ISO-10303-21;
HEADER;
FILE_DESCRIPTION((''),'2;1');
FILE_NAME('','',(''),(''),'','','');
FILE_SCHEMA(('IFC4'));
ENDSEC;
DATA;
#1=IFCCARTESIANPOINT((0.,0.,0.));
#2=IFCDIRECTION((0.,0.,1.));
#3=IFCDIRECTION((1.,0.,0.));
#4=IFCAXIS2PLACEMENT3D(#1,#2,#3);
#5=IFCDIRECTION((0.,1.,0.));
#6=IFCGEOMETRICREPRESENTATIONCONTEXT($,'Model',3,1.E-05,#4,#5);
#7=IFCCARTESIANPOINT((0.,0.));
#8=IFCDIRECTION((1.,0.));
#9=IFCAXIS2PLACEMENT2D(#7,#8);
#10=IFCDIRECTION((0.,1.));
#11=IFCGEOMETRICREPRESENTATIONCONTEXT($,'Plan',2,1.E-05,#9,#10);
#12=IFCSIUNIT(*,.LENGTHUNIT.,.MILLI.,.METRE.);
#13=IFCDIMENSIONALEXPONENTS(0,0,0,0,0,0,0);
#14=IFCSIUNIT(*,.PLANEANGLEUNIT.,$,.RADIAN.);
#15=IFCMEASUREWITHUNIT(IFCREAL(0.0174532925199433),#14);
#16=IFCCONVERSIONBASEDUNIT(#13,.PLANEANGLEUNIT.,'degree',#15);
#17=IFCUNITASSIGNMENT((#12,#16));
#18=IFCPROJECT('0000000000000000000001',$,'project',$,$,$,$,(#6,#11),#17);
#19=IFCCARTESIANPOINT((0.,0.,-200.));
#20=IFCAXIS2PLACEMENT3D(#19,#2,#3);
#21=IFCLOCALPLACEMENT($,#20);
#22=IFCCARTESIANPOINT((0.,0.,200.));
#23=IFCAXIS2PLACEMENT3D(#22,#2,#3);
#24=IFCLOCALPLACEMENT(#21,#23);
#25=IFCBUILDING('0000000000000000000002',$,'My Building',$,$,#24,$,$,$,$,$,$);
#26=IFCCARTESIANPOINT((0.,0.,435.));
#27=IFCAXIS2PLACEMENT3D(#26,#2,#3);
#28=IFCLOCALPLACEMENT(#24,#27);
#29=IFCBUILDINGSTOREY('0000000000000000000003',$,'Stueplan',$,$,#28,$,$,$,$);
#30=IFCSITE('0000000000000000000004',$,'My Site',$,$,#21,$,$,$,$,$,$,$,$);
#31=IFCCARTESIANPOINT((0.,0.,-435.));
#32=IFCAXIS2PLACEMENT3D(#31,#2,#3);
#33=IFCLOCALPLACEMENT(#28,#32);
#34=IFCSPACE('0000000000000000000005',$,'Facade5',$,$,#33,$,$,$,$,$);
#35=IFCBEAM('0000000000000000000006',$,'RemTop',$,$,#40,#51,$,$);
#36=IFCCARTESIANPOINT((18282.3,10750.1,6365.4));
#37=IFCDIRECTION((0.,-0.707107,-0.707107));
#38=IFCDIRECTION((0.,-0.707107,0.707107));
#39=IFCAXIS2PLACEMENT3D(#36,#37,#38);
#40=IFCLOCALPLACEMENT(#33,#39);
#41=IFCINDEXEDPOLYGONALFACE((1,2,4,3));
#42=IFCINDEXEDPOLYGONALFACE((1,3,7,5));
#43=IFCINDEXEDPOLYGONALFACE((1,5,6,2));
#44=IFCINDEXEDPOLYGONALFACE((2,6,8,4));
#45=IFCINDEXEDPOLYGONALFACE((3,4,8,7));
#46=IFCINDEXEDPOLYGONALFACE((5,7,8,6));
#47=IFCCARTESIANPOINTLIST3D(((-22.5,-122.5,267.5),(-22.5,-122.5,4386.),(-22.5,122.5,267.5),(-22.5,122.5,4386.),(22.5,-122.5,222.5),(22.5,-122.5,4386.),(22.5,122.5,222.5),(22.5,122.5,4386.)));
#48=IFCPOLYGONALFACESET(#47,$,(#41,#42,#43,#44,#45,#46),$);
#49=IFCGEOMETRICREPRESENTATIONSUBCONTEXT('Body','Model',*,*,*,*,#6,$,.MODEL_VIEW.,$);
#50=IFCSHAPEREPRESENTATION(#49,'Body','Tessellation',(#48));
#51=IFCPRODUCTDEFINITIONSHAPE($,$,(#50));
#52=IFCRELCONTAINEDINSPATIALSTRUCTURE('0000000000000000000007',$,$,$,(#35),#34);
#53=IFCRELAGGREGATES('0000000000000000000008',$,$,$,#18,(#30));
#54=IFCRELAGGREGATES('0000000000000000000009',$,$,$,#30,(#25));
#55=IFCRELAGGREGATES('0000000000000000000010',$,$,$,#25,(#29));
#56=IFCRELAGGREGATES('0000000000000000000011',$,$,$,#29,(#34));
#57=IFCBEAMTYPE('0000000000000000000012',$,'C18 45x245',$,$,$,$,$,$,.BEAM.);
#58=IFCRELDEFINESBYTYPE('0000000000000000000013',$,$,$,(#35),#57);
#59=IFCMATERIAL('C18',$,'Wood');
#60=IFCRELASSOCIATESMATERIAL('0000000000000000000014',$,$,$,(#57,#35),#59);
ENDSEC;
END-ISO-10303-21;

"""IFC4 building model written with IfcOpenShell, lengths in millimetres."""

from ifc_helpers import new_model, entity, si_unit, converted_unit, direction, frame, origin_with_axes, origin_2d_with_axis, place, context, subcontext, project, spatial, rectangle, extrude, clip, halfspace, material, material_profile, profile_set, profile_usage, type_object, element, save


model = new_model("IFC4")

# Units and contexts
model_context = context("Model", 3, precision=1e-05, world=origin_with_axes(), true_north=direction((0.0, 1.0, 0.0)))
plan_context = context("Plan", 2, precision=1e-05, world=origin_2d_with_axis(), true_north=direction((0.0, 1.0)))
body_context_1 = subcontext(model_context, "Body", "Model", "MODEL_VIEW")
ifc_project = project(units=[si_unit("LENGTHUNIT", "METRE", prefix="MILLI"), converted_unit("PLANEANGLEUNIT", "degree", entity("IfcReal", 0.0174532925199433), si_unit("PLANEANGLEUNIT", "RADIAN"), dimensions=[0, 0, 0, 0, 0, 0, 0])], contexts=[model_context, plan_context])

# Site, building, storey
site_placement = place(None, frame((0.0, 0.0, -200.0), z_axis=(0.0, 0.0, 1.0), x_axis=(1.0, 0.0, 0.0)))
site = spatial("IfcSite", under=ifc_project, at=site_placement, Name="My Site")
building_placement = place(site_placement, frame((0.0, 0.0, 200.0), z_axis=(0.0, 0.0, 1.0), x_axis=(1.0, 0.0, 0.0)))
building = spatial("IfcBuilding", under=site, at=building_placement, Name="My Building")
storey_placement = place(building_placement, frame((0.0, 0.0, 435.0), z_axis=(0.0, 0.0, 1.0), x_axis=(1.0, 0.0, 0.0)))
storey = spatial("IfcBuildingStorey", under=building, at=storey_placement, Name="Stueplan")

# Shared definitions
ifc_material = material(Name="C18", Category="Wood")

# Shared definitions
space_1_placement = place(storey_placement, frame((0.0, 0.0, -435.0), z_axis=(0.0, 0.0, 1.0), x_axis=(1.0, 0.0, 0.0)))
space_1 = spatial("IfcSpace", under=storey, at=space_1_placement, Name="Facade5")

# Beam
ifc_material_profile_1 = material_profile(ifc_material, rectangle(XDim=45.0, YDim=245.0), Name="concrete")
ifc_profile_set_1 = profile_set([ifc_material_profile_1], Name="woodStructural")
beam_type_1 = type_object("IfcBeamType", Name="C18 45x245", PredefinedType="BEAM", material=ifc_profile_set_1)
ifc_profile_usage_1 = profile_usage(ifc_profile_set_1)
beam_1_placement = place(space_1_placement, frame((18282.3, 10750.1, 6365.4), z_axis=(0.0, -0.707107, -0.707107), x_axis=(0.0, -0.707107, 0.707107)))
element("IfcBeam", 1, at=beam_1_placement, inside=space_1, type_object=beam_type_1, material=ifc_profile_usage_1, Name="RemTop", context=body_context_1, shape_type="Clipping", body=[
    clip(extrude(rectangle(XDim=45.0, YDim=245.0), origin_with_axes(), (0.0, 0.0, 1.0), 4386.0), halfspace(frame((-4039.1, 122.5, 4284.1), z_axis=(-0.707107, -0.000001, -0.707107), x_axis=(-0.000001, 1.0, 0.0)), False)),
])

save(model, "model.ifc")
